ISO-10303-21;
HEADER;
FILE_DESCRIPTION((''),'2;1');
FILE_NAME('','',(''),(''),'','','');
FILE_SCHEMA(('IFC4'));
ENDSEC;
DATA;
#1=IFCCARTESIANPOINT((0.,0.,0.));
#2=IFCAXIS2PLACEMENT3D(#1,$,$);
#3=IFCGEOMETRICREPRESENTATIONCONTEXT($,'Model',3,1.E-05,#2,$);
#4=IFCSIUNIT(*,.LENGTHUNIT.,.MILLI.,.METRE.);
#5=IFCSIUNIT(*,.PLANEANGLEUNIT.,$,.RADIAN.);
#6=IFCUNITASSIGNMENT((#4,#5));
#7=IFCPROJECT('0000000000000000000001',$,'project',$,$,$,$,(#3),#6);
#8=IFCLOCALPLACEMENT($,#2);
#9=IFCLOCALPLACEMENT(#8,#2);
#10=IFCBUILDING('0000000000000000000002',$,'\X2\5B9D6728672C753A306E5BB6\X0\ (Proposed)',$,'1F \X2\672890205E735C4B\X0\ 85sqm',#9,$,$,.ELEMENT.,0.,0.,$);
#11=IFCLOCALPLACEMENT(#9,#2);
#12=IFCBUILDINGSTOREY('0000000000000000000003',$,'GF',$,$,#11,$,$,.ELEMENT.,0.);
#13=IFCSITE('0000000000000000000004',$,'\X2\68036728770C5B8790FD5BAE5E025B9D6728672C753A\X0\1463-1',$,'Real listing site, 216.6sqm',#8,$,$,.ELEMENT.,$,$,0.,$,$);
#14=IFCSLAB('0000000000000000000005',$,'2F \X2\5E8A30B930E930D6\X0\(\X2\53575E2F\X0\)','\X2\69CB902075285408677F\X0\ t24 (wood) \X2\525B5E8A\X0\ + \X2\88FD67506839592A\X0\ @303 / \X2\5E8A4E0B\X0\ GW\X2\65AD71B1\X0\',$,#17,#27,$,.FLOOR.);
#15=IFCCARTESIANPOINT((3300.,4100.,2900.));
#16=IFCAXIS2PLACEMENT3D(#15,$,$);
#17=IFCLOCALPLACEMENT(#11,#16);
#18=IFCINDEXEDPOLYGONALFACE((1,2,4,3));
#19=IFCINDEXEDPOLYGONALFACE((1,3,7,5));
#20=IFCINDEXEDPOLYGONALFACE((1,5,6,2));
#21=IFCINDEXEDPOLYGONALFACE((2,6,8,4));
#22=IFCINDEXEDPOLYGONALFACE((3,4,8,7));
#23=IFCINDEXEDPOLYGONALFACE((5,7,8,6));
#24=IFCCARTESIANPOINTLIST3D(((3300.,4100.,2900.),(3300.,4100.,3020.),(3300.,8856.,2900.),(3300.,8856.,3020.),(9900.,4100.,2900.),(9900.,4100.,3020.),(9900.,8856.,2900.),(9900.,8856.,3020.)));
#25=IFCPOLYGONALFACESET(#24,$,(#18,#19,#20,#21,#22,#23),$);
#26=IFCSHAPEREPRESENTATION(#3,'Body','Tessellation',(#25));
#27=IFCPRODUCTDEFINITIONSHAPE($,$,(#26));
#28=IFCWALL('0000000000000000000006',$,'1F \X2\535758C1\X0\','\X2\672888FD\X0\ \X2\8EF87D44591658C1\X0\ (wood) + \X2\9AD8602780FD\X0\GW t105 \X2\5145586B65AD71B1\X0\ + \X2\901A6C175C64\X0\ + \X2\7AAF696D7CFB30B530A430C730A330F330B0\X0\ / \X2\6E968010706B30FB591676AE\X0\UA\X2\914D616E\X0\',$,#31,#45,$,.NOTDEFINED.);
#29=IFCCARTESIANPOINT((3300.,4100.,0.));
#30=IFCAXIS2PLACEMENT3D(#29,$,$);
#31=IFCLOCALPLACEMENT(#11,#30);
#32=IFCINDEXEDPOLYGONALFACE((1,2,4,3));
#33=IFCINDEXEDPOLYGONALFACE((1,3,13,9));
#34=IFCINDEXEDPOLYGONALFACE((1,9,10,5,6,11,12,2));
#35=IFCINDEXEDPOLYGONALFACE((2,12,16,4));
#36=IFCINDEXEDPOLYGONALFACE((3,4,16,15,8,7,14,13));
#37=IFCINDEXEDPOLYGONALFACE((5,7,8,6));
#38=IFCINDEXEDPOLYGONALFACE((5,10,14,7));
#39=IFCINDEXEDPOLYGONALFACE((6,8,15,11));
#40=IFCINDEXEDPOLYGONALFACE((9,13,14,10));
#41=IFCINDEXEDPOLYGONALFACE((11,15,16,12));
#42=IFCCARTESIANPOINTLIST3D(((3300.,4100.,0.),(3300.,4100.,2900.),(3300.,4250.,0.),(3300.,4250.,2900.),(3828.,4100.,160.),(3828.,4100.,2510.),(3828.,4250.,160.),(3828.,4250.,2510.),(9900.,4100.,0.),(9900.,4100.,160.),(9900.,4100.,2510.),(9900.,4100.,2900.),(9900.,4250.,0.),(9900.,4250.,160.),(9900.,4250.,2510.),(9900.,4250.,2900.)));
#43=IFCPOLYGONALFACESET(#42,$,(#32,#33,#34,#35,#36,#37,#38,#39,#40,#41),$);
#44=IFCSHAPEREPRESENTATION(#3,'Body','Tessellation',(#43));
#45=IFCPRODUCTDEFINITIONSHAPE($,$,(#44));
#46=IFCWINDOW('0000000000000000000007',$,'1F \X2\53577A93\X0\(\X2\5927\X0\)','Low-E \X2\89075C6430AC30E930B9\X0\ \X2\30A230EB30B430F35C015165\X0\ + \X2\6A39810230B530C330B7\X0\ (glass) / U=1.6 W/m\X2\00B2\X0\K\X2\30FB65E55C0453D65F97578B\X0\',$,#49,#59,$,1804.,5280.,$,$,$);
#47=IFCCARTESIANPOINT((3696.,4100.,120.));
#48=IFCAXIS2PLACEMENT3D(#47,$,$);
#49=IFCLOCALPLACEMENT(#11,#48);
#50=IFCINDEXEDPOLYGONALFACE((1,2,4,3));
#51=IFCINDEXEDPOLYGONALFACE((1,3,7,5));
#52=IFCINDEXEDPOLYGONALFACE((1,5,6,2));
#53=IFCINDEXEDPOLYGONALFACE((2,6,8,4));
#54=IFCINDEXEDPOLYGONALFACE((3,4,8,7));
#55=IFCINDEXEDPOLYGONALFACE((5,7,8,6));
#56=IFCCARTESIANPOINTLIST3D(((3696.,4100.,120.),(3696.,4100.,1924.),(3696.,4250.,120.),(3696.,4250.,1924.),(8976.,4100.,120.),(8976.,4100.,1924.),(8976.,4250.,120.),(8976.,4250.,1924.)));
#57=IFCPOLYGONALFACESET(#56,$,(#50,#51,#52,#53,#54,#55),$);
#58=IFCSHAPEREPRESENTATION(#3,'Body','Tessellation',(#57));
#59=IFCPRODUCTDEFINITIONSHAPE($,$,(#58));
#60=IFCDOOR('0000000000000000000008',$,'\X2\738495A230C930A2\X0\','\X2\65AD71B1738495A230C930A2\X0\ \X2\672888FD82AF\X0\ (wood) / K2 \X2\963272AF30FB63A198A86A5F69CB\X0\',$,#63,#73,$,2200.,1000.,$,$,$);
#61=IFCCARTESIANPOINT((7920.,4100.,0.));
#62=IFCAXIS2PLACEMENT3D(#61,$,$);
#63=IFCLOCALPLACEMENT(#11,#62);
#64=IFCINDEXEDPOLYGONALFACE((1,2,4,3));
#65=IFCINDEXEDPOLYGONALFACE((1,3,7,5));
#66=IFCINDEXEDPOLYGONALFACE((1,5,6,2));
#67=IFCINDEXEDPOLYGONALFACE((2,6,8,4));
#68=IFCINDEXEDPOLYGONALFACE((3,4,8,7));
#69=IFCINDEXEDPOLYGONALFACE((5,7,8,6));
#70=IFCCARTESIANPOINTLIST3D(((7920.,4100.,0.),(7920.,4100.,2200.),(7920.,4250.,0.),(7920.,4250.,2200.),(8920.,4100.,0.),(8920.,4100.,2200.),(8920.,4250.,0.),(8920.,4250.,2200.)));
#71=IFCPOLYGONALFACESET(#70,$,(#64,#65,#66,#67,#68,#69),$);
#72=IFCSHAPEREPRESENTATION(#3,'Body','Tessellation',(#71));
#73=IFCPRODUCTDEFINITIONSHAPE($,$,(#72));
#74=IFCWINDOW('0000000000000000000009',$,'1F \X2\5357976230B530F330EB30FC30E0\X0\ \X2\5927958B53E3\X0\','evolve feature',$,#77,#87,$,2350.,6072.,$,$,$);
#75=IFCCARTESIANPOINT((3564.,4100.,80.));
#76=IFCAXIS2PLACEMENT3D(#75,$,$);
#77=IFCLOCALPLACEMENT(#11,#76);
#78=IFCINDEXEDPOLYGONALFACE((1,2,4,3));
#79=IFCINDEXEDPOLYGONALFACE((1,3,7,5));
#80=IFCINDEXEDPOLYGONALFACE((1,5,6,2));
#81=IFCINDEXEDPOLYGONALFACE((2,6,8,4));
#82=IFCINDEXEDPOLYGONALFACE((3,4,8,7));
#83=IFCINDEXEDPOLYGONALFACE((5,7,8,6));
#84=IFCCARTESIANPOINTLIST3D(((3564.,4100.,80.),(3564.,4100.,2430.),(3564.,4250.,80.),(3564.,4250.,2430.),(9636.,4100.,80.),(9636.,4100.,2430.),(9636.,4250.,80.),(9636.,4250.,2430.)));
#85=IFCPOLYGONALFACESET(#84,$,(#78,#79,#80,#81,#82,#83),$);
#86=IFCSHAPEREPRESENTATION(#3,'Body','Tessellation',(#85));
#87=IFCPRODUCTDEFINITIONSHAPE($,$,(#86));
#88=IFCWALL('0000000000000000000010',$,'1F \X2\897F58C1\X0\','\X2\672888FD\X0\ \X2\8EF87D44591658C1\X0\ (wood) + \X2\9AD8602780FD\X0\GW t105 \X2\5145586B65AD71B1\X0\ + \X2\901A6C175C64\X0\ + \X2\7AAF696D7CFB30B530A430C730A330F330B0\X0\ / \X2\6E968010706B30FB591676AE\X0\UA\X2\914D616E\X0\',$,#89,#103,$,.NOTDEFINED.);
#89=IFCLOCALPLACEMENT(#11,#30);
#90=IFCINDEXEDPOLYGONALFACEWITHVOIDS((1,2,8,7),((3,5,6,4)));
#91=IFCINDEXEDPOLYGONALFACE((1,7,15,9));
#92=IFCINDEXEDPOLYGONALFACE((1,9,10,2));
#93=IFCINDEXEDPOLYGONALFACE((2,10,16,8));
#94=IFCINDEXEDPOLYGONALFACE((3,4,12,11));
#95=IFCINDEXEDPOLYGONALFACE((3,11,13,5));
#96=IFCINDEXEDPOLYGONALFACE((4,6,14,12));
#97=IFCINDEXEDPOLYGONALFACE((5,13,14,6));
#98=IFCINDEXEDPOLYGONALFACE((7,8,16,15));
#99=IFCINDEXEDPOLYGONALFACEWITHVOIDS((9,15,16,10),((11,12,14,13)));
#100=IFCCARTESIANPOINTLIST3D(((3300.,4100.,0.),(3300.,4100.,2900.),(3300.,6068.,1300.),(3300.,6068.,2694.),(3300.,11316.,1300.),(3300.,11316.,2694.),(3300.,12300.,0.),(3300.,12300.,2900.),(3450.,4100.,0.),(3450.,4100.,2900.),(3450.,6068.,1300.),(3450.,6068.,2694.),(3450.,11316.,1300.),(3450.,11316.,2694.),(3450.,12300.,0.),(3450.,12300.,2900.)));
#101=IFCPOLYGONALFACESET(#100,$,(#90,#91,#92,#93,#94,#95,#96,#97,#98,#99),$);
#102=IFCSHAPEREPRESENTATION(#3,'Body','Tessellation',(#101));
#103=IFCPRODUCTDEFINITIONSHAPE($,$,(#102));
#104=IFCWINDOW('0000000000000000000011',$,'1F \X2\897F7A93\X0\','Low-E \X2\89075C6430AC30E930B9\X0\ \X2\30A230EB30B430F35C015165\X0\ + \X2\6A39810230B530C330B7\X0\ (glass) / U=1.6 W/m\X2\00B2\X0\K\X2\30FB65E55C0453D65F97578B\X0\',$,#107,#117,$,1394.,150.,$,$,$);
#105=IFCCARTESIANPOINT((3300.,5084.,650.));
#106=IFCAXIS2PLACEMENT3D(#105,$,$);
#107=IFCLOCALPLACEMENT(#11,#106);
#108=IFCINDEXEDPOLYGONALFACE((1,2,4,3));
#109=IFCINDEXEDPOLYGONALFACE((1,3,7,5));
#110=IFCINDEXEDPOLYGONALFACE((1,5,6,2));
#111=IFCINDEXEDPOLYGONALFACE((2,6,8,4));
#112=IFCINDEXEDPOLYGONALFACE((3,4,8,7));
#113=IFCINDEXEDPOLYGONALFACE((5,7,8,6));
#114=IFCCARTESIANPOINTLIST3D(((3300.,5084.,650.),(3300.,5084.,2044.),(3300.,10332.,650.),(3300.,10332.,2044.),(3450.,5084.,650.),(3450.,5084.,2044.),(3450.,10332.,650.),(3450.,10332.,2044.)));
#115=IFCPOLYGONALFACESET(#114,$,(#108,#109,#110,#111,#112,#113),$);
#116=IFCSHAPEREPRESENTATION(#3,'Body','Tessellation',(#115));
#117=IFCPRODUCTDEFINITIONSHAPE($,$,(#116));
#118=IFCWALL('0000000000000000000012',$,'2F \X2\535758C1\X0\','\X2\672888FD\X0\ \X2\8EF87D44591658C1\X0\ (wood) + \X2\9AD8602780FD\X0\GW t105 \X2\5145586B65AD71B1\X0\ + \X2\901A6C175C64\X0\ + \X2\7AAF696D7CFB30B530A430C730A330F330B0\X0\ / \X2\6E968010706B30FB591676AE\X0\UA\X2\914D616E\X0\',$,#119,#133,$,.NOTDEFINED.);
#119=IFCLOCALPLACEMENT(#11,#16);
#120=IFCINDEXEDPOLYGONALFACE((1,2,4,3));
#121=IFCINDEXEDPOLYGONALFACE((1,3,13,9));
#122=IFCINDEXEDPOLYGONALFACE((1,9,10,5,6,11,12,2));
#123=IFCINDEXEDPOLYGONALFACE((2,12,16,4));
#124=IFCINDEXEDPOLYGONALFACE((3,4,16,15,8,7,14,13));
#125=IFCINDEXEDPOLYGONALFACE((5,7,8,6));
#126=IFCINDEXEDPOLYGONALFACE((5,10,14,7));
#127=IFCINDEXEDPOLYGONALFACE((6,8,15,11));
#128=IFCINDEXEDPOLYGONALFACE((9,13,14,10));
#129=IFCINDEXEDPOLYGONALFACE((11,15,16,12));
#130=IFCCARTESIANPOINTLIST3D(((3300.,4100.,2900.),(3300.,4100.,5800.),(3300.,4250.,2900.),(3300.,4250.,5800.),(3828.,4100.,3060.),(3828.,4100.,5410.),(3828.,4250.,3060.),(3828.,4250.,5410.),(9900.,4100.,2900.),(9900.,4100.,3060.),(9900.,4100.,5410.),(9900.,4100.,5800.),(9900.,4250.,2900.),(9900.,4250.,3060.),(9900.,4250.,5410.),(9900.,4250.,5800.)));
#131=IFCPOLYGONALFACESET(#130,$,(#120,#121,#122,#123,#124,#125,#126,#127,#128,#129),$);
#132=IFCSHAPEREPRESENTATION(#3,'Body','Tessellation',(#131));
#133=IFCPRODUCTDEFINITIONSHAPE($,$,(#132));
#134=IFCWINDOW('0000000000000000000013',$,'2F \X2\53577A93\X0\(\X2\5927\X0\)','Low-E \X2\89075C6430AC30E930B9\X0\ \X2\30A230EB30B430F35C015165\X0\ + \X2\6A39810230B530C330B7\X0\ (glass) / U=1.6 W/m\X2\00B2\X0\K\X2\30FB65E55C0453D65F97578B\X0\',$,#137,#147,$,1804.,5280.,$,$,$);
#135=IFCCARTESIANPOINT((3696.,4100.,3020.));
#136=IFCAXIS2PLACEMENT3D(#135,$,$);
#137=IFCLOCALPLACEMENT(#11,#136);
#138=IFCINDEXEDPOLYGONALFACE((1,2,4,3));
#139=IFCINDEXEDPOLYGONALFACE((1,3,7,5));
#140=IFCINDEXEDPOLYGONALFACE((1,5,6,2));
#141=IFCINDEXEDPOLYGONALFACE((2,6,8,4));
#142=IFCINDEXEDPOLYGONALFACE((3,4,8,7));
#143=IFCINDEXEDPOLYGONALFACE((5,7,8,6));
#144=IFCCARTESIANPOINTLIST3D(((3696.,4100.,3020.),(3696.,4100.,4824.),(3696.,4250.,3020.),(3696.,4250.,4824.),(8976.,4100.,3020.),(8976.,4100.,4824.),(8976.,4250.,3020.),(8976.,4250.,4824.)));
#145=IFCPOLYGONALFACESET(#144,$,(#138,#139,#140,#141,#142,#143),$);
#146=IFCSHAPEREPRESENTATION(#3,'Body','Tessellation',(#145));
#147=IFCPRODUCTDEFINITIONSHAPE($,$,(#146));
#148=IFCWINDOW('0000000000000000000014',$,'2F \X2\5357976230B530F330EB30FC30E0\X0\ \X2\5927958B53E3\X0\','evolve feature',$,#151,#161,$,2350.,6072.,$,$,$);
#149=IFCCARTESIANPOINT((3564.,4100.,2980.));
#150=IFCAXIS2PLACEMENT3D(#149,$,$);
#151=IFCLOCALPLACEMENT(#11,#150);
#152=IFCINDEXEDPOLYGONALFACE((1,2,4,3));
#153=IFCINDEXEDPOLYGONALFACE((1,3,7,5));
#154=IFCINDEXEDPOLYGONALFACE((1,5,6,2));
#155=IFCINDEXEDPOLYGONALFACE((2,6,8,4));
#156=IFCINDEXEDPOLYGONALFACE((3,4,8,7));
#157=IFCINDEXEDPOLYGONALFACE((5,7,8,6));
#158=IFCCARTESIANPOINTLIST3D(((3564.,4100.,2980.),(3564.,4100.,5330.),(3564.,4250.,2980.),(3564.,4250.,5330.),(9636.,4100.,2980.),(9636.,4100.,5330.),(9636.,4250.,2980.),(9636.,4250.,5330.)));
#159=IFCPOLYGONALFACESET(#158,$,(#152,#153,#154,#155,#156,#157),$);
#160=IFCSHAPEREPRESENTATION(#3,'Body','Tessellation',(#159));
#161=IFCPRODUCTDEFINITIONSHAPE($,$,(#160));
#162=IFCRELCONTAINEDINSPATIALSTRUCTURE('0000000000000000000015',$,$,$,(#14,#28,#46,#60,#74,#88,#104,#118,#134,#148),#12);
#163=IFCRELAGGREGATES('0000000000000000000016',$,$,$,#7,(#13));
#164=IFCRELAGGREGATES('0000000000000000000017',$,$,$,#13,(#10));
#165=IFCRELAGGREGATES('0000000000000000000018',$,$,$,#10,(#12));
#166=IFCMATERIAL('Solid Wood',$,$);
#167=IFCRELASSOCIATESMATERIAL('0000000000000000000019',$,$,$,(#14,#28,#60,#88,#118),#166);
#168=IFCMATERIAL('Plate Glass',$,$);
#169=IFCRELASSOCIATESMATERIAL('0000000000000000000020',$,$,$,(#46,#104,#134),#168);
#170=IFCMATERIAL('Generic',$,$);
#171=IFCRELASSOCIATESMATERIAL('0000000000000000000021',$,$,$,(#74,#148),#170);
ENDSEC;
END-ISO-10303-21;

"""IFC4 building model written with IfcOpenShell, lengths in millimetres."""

from ifc_helpers import new_model, si_unit, frame, frame_2d, origin, place, context, project, spatial, rectangle, extrude, material, element, fill, save


model = new_model("IFC4")

# Units and contexts
model_context = context("Model", 3, precision=1e-05, world=origin())
ifc_project = project(units=[si_unit("LENGTHUNIT", "METRE", prefix="MILLI"), si_unit("PLANEANGLEUNIT", "RADIAN")], contexts=[model_context])

# Site, building, storey
site_placement = place(None, origin())
site = spatial("IfcSite", under=ifc_project, at=site_placement, Name="栃木県宇都宮市宝木本町1463-1", ObjectType="Real listing site, 216.6sqm", CompositionType="ELEMENT", RefElevation=0.0)
building_placement = place(site_placement, origin())
building = spatial("IfcBuilding", under=site, at=building_placement, Name="宝木本町の家 (Proposed)", ObjectType="1F 木造平屋 85sqm", CompositionType="ELEMENT", ElevationOfRefHeight=0.0, ElevationOfTerrain=0.0)
storey_placement = place(building_placement, origin())
storey = spatial("IfcBuildingStorey", under=building, at=storey_placement, Name="GF", CompositionType="ELEMENT", Elevation=0.0)

# Slab
ifc_material_1 = material(Name="Solid Wood")
slab_1_placement = place(storey_placement, frame((3300.0, 4100.0, 2900.0)))
element("IfcSlab", 1, at=slab_1_placement, inside=storey, material=ifc_material_1, Name="2F 床スラブ(南帯)", Description="構造用合板 t24 (wood) 剛床 + 製材根太 @303 / 床下 GW断熱", PredefinedType="FLOOR", context=model_context, shape_type="SweptSolid", body=[
    extrude(rectangle(XDim=6600.0, YDim=4756.0, at=frame_2d((3300.0, 2378.0))), frame((3300.0, 4100.0, 2900.0)), (0.0, 0.0, 1.0), 120.0),
])
ifc_material_2 = material(Name="Generic")

# Wall, openings, windows, door
wall_1_placement = place(storey_placement, frame((3300.0, 4100.0, 0.0)))
wall_1 = element("IfcWall", 2, at=wall_1_placement, inside=storey, material=ifc_material_1, Name="1F 南壁", Description="木製 軸組外壁 (wood) + 高性能GW t105 充填断熱 + 通気層 + 窯業系サイディング / 準耐火・外皮UA配慮", PredefinedType="NOTDEFINED", context=model_context, shape_type="SweptSolid", body=[
    extrude(rectangle(XDim=6600.0, YDim=150.0, at=frame_2d((3300.0, 75.0))), frame((3300.0, 4100.0, 0.0)), (0.0, 0.0, 1.0), 2900.0),
])
opening_1_placement = place(storey_placement, frame((3696.0, 4100.0, 120.0)))
opening_1 = element("IfcOpeningElement", 3, at=opening_1_placement, cuts=wall_1, PredefinedType="NOTDEFINED", context=model_context, shape_type="SweptSolid", body=[
    extrude(rectangle(XDim=5280.0, YDim=150.0, at=frame_2d((2640.0, 75.0))), frame((3696.0, 4100.0, 120.0)), (0.0, 0.0, 1.0), 1804.0),
])
opening_2_placement = place(storey_placement, frame((7920.0, 4100.0, 0.0)))
opening_2 = element("IfcOpeningElement", 4, at=opening_2_placement, cuts=wall_1, PredefinedType="NOTDEFINED", context=model_context, shape_type="SweptSolid", body=[
    extrude(rectangle(XDim=1000.0, YDim=150.0, at=frame_2d((500.0, 75.0))), frame((7920.0, 4100.0, 0.0)), (0.0, 0.0, 1.0), 2200.0),
])
opening_3_placement = place(storey_placement, frame((3564.0, 4100.0, 80.0)))
opening_3 = element("IfcOpeningElement", 5, at=opening_3_placement, cuts=wall_1, PredefinedType="NOTDEFINED", context=model_context, shape_type="SweptSolid", body=[
    extrude(rectangle(XDim=6072.0, YDim=150.0, at=frame_2d((3036.0, 75.0))), frame((3564.0, 4100.0, 80.0)), (0.0, 0.0, 1.0), 2350.0),
])
ifc_material_3 = material(Name="Plate Glass")
window_1_placement = place(storey_placement, frame((3696.0, 4100.0, 120.0)))
window_1 = element("IfcWindow", 6, at=window_1_placement, inside=storey, material=ifc_material_3, Name="1F 南窓(大)", Description="Low-E 複層ガラス アルゴン封入 + 樹脂サッシ (glass) / U=1.6 W/m²K・日射取得型", OverallHeight=1804.0, OverallWidth=5280.0, context=model_context, shape_type="SweptSolid", body=[
    extrude(rectangle(XDim=5280.0, YDim=150.0, at=frame_2d((2640.0, 75.0))), frame((3696.0, 4100.0, 120.0)), (0.0, 0.0, 1.0), 1804.0),
])
fill(opening_1, window_1)
door_placement = place(storey_placement, frame((7920.0, 4100.0, 0.0)))
door = element("IfcDoor", 7, at=door_placement, inside=storey, material=ifc_material_1, Name="玄関ドア", Description="断熱玄関ドア 木製芯 (wood) / K2 防犯・採風機構", OverallHeight=2200.0, OverallWidth=1000.0, context=model_context, shape_type="SweptSolid", body=[
    extrude(rectangle(XDim=1000.0, YDim=150.0, at=frame_2d((500.0, 75.0))), frame((7920.0, 4100.0, 0.0)), (0.0, 0.0, 1.0), 2200.0),
])
fill(opening_2, door)
window_2_placement = place(storey_placement, frame((3564.0, 4100.0, 80.0)))
window_2 = element("IfcWindow", 8, at=window_2_placement, inside=storey, material=ifc_material_2, Name="1F 南面サンルーム 大開口", Description="evolve feature", OverallHeight=2350.0, OverallWidth=6072.0, context=model_context, shape_type="SweptSolid", body=[
    extrude(rectangle(XDim=6072.0, YDim=150.0, at=frame_2d((3036.0, 75.0))), frame((3564.0, 4100.0, 80.0)), (0.0, 0.0, 1.0), 2350.0),
])
fill(opening_3, window_2)

# Wall, opening, window
wall_2_placement = place(storey_placement, frame((3300.0, 4100.0, 0.0)))
wall_2 = element("IfcWall", 9, at=wall_2_placement, inside=storey, material=ifc_material_1, Name="1F 西壁", Description="木製 軸組外壁 (wood) + 高性能GW t105 充填断熱 + 通気層 + 窯業系サイディング / 準耐火・外皮UA配慮", PredefinedType="NOTDEFINED", context=model_context, shape_type="SweptSolid", body=[
    extrude(rectangle(XDim=150.0, YDim=8200.0, at=frame_2d((75.0, 4100.0))), frame((3300.0, 4100.0, 0.0)), (0.0, 0.0, 1.0), 2900.0),
])
opening_4_placement = place(storey_placement, frame((3300.0, 5084.0, 650.0)))
opening_4 = element("IfcOpeningElement", 10, at=opening_4_placement, cuts=wall_2, PredefinedType="NOTDEFINED", context=model_context, shape_type="SweptSolid", body=[
    extrude(rectangle(XDim=150.0, YDim=5248.0, at=frame_2d((75.0, 2624.0))), frame((3300.0, 5084.0, 650.0)), (0.0, 0.0, 1.0), 1394.0),
])
window_3_placement = place(storey_placement, frame((3300.0, 5084.0, 650.0)))
window_3 = element("IfcWindow", 11, at=window_3_placement, inside=storey, material=ifc_material_3, Name="1F 西窓", Description="Low-E 複層ガラス アルゴン封入 + 樹脂サッシ (glass) / U=1.6 W/m²K・日射取得型", OverallHeight=1394.0, OverallWidth=150.0, context=model_context, shape_type="SweptSolid", body=[
    extrude(rectangle(XDim=150.0, YDim=5248.0, at=frame_2d((75.0, 2624.0))), frame((3300.0, 5084.0, 650.0)), (0.0, 0.0, 1.0), 1394.0),
])
fill(opening_4, window_3)

# Wall, openings, windows
wall_3_placement = place(storey_placement, frame((3300.0, 4100.0, 2900.0)))
wall_3 = element("IfcWall", 12, at=wall_3_placement, inside=storey, material=ifc_material_1, Name="2F 南壁", Description="木製 軸組外壁 (wood) + 高性能GW t105 充填断熱 + 通気層 + 窯業系サイディング / 準耐火・外皮UA配慮", PredefinedType="NOTDEFINED", context=model_context, shape_type="SweptSolid", body=[
    extrude(rectangle(XDim=6600.0, YDim=150.0, at=frame_2d((3300.0, 75.0))), frame((3300.0, 4100.0, 2900.0)), (0.0, 0.0, 1.0), 2900.0),
])
opening_5_placement = place(storey_placement, frame((3696.0, 4100.0, 3020.0)))
opening_5 = element("IfcOpeningElement", 13, at=opening_5_placement, cuts=wall_3, PredefinedType="NOTDEFINED", context=model_context, shape_type="SweptSolid", body=[
    extrude(rectangle(XDim=5280.0, YDim=150.0, at=frame_2d((2640.0, 75.0))), frame((3696.0, 4100.0, 3020.0)), (0.0, 0.0, 1.0), 1804.0),
])
opening_6_placement = place(storey_placement, frame((3564.0, 4100.0, 2980.0)))
opening_6 = element("IfcOpeningElement", 14, at=opening_6_placement, cuts=wall_3, PredefinedType="NOTDEFINED", context=model_context, shape_type="SweptSolid", body=[
    extrude(rectangle(XDim=6072.0, YDim=150.0, at=frame_2d((3036.0, 75.0))), frame((3564.0, 4100.0, 2980.0)), (0.0, 0.0, 1.0), 2350.0),
])
window_4_placement = place(storey_placement, frame((3696.0, 4100.0, 3020.0)))
window_4 = element("IfcWindow", 15, at=window_4_placement, inside=storey, material=ifc_material_3, Name="2F 南窓(大)", Description="Low-E 複層ガラス アルゴン封入 + 樹脂サッシ (glass) / U=1.6 W/m²K・日射取得型", OverallHeight=1804.0, OverallWidth=5280.0, context=model_context, shape_type="SweptSolid", body=[
    extrude(rectangle(XDim=5280.0, YDim=150.0, at=frame_2d((2640.0, 75.0))), frame((3696.0, 4100.0, 3020.0)), (0.0, 0.0, 1.0), 1804.0),
])
fill(opening_5, window_4)
window_5_placement = place(storey_placement, frame((3564.0, 4100.0, 2980.0)))
window_5 = element("IfcWindow", 16, at=window_5_placement, inside=storey, material=ifc_material_2, Name="2F 南面サンルーム 大開口", Description="evolve feature", OverallHeight=2350.0, OverallWidth=6072.0, context=model_context, shape_type="SweptSolid", body=[
    extrude(rectangle(XDim=6072.0, YDim=150.0, at=frame_2d((3036.0, 75.0))), frame((3564.0, 4100.0, 2980.0)), (0.0, 0.0, 1.0), 2350.0),
])
fill(opening_6, window_5)

save(model, "model.ifc")
